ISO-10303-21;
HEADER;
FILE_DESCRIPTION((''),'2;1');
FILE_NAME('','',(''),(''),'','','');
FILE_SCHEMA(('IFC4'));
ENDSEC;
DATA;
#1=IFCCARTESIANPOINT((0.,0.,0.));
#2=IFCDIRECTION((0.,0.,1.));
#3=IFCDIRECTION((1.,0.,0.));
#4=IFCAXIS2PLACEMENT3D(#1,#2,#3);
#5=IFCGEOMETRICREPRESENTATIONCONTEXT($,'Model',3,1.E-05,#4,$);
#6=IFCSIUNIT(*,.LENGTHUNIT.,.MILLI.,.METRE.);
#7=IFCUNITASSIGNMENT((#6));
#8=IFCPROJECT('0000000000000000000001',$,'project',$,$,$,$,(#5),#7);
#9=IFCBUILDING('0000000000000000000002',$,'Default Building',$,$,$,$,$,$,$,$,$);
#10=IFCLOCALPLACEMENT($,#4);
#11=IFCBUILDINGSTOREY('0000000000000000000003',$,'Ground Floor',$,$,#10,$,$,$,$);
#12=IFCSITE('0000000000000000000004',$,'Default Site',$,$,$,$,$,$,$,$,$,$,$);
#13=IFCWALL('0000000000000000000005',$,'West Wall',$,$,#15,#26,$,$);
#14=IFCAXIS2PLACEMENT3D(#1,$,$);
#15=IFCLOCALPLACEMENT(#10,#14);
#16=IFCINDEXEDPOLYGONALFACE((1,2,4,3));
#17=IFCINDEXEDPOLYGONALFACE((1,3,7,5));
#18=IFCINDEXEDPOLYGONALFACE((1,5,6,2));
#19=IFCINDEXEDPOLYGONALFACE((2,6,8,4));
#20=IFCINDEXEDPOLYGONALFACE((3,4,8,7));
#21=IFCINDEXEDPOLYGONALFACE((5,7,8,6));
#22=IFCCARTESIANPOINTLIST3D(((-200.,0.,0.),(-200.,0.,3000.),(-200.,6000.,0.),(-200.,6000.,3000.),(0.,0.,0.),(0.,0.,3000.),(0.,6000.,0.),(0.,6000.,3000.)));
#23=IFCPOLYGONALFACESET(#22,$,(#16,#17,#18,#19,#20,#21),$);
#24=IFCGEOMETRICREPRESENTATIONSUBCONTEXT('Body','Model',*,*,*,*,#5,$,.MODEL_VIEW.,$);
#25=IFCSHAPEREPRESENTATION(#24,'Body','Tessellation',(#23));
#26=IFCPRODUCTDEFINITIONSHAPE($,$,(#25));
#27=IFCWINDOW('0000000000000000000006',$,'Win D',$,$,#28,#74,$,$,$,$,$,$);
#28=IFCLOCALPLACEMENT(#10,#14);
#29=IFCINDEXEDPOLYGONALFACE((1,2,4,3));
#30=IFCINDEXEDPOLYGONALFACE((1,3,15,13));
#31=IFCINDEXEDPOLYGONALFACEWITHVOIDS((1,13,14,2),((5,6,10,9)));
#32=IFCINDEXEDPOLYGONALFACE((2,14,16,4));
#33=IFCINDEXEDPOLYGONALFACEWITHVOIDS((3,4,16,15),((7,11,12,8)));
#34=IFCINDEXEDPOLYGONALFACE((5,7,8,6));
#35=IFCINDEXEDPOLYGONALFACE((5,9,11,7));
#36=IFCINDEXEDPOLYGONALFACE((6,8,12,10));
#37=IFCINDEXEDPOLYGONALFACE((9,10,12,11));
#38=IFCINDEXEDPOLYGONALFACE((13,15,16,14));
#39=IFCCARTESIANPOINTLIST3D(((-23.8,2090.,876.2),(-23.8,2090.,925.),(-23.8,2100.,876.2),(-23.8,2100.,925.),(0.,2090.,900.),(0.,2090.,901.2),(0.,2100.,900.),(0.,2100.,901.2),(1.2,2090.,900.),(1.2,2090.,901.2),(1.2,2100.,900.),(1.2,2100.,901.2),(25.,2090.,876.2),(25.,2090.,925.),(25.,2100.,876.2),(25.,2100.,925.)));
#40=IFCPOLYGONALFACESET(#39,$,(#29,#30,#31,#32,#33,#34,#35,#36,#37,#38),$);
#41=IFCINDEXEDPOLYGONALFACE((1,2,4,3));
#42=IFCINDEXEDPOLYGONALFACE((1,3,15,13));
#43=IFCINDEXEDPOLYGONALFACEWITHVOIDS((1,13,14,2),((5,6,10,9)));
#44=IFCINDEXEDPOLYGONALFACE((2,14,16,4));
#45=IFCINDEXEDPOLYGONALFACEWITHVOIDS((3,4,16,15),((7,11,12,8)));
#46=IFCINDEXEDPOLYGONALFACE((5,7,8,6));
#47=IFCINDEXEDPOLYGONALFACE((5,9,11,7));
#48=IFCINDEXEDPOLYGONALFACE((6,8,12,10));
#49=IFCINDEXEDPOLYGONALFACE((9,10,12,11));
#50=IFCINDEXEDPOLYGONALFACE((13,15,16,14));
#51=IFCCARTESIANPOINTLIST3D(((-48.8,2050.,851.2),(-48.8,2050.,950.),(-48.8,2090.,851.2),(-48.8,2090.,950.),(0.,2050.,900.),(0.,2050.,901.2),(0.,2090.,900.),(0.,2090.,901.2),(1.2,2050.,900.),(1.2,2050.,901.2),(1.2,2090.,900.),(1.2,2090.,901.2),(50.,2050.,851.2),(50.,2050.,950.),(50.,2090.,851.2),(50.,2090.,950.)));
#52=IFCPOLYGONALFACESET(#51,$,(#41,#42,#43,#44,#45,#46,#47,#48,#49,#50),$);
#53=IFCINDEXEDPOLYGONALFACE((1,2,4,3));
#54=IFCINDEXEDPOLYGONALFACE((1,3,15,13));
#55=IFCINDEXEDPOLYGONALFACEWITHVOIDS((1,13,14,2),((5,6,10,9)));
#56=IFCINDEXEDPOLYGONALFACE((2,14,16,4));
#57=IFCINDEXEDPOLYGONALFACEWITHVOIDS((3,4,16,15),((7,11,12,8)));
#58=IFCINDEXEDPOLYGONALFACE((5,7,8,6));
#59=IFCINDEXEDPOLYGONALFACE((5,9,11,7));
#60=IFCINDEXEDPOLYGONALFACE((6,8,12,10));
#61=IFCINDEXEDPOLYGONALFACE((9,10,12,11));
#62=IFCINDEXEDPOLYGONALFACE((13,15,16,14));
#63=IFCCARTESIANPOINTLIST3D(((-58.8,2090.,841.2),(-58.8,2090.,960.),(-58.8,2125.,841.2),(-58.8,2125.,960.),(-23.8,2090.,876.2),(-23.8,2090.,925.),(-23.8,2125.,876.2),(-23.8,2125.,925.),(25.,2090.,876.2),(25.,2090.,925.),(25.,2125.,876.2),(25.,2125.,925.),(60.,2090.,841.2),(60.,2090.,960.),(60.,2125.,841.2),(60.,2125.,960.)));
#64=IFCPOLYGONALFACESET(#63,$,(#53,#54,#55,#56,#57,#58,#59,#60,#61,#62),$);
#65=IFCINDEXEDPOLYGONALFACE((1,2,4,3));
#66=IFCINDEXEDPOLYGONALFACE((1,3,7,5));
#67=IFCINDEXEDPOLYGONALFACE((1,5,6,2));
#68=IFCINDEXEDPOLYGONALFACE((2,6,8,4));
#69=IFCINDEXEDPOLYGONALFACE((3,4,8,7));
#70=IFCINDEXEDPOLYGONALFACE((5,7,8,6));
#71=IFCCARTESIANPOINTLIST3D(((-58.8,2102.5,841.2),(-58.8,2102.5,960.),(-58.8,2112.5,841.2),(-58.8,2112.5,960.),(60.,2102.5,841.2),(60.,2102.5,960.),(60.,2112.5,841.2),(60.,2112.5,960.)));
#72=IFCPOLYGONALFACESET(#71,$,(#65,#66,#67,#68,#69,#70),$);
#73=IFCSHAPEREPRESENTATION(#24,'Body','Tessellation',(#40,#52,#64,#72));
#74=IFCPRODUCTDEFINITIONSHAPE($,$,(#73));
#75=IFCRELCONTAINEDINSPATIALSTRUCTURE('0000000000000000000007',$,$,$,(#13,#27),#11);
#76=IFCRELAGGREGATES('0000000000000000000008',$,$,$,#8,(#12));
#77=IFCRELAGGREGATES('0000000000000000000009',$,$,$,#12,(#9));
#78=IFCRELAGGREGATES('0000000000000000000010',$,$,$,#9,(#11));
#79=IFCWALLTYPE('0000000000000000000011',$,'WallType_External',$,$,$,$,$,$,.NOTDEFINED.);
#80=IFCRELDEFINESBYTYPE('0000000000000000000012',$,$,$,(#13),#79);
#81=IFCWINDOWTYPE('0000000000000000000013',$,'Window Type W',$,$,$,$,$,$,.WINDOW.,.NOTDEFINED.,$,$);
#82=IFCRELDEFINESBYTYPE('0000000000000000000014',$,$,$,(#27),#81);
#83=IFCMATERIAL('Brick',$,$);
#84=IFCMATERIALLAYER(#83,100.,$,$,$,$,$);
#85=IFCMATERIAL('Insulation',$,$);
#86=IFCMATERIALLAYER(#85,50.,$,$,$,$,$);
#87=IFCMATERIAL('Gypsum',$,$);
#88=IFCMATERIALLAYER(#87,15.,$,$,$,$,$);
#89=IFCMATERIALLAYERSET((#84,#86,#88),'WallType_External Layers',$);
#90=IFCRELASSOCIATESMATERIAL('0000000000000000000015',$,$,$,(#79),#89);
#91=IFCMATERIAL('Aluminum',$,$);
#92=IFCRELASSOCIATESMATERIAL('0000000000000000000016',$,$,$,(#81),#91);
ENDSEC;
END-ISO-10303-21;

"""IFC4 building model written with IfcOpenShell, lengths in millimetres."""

from ifc_helpers import new_model, si_unit, frame, origin_with_axes, place, context, subcontext, project, spatial, line, indexed_curve, outline, extrude, material, layer, layer_set, type_object, element, fill, save


model = new_model("IFC4")

# Units and contexts
model_context = context("Model", 3, precision=1e-05, world=origin_with_axes())
body_context = subcontext(model_context, "Body", "Model", "MODEL_VIEW")
ifc_project = project(units=[si_unit("LENGTHUNIT", "METRE", prefix="MILLI")], contexts=[model_context])

# Site, building, storey
site = spatial("IfcSite", under=ifc_project, Name="Default Site")
building = spatial("IfcBuilding", under=site, Name="Default Building")
storey_placement = place(None, origin_with_axes())
storey = spatial("IfcBuildingStorey", under=building, at=storey_placement, Name="Ground Floor")

# Shared definitions
ifc_material_1 = material(Name="Brick")
ifc_layer_1 = layer(ifc_material_1, 100.0)
ifc_material_2 = material(Name="Insulation")
ifc_layer_2 = layer(ifc_material_2, 50.0)
ifc_material_3 = material(Name="Gypsum")
ifc_layer_3 = layer(ifc_material_3, 15.0)
ifc_layer_set_1 = layer_set([ifc_layer_1, ifc_layer_2, ifc_layer_3], Name="WallType_External Layers")
wall_type = type_object("IfcWallType", Name="WallType_External", PredefinedType="NOTDEFINED", material=ifc_layer_set_1)

# Shared definitions
ifc_material_4 = material(Name="Aluminum")
window_type = type_object("IfcWindowType", Name="Window Type W", PartitioningType="NOTDEFINED", PredefinedType="WINDOW", material=ifc_material_4)

# Wall, opening, window
wall_1_placement = place(storey_placement, origin_with_axes())
wall_1 = element("IfcWall", 1, at=wall_1_placement, inside=storey, type_object=wall_type, Name="West Wall", context=body_context, shape_type="SweptSolid", body=[
    extrude(outline(indexed_curve([(0.0, 0.0), (0.0, 6000.0), (-200.0, 6000.0), (-200.0, 0.0), (0.0, 0.0)])), None, (0.0, 0.0, 1.0), 3000.0),
])
opening_1_placement = place(wall_1_placement, frame((0.0, 0.0, 900.0), z_axis=(0.0, 0.0, 1.0), x_axis=(1.0, 0.0, 0.0)))
opening_1 = element("IfcOpeningElement", 2, at=opening_1_placement, cuts=wall_1, context=body_context, shape_type="SweptSolid", body=[
    extrude(outline(indexed_curve([(0.0, 2000.0), (1200.0, 2000.0), (1200.0, 2200.0), (0.0, 2200.0), (0.0, 2000.0)])), None, (0.0, 0.0, 1.0), 1200.0),
])
window_1_placement = place(storey_placement, frame((0.0, 2000.0, 900.0), z_axis=(0.0, 0.0, 1.0), x_axis=(1.0, 0.0, 0.0)))
window_1 = element("IfcWindow", 3, at=window_1_placement, inside=storey, type_object=window_type, Name="Win D", context=body_context, shape_type="SweptSolid", body=[
    extrude(outline(indexed_curve([(0.0, 0.0), (1.2, 0.0), (1.2, 1.2), (0.0, 1.2)], segments=[line(1, 2, 3, 4, 1)]), holes=[indexed_curve([(25.0, 25.0), (-23.8, 25.0), (-23.8, -23.8), (25.0, -23.8)], segments=[line(1, 2, 3, 4, 1)])]), frame((0.0, 90.0, 0.0), z_axis=(0.0, -1.0, 0.0), x_axis=(1.0, 0.0, 0.0)), (0.0, 0.0, -1.0), 10.0),
    extrude(outline(indexed_curve([(0.0, 0.0), (1.2, 0.0), (1.2, 1.2), (0.0, 1.2)], segments=[line(1, 2, 3, 4, 1)]), holes=[indexed_curve([(50.0, 50.0), (-48.8, 50.0), (-48.8, -48.8), (50.0, -48.8)], segments=[line(1, 2, 3, 4, 1)])]), frame((0.0, 50.0, 0.0), z_axis=(0.0, -1.0, 0.0), x_axis=(1.0, 0.0, 0.0)), (0.0, 0.0, -1.0), 40.0),
    extrude(outline(indexed_curve([(0.0, 0.0), (-48.8, 0.0), (-48.8, -48.8), (0.0, -48.8)], segments=[line(1, 2, 3, 4, 1)]), holes=[indexed_curve([(35.0, 35.0), (-83.8, 35.0), (-83.8, -83.8), (35.0, -83.8)], segments=[line(1, 2, 3, 4, 1)])]), frame((25.0, 90.0, 25.0), z_axis=(0.0, -1.0, 0.0), x_axis=(1.0, 0.0, 0.0)), (0.0, 0.0, -1.0), 35.0),
    extrude(outline(indexed_curve([(35.0, 35.0), (-83.8, 35.0), (-83.8, -83.8), (35.0, -83.8)], segments=[line(1, 2, 3, 4, 1)])), frame((25.0, 102.5, 25.0), z_axis=(0.0, -1.0, 0.0), x_axis=(1.0, 0.0, 0.0)), (0.0, 0.0, -1.0), 10.0),
])
fill(opening_1, window_1)

save(model, "model.ifc")
